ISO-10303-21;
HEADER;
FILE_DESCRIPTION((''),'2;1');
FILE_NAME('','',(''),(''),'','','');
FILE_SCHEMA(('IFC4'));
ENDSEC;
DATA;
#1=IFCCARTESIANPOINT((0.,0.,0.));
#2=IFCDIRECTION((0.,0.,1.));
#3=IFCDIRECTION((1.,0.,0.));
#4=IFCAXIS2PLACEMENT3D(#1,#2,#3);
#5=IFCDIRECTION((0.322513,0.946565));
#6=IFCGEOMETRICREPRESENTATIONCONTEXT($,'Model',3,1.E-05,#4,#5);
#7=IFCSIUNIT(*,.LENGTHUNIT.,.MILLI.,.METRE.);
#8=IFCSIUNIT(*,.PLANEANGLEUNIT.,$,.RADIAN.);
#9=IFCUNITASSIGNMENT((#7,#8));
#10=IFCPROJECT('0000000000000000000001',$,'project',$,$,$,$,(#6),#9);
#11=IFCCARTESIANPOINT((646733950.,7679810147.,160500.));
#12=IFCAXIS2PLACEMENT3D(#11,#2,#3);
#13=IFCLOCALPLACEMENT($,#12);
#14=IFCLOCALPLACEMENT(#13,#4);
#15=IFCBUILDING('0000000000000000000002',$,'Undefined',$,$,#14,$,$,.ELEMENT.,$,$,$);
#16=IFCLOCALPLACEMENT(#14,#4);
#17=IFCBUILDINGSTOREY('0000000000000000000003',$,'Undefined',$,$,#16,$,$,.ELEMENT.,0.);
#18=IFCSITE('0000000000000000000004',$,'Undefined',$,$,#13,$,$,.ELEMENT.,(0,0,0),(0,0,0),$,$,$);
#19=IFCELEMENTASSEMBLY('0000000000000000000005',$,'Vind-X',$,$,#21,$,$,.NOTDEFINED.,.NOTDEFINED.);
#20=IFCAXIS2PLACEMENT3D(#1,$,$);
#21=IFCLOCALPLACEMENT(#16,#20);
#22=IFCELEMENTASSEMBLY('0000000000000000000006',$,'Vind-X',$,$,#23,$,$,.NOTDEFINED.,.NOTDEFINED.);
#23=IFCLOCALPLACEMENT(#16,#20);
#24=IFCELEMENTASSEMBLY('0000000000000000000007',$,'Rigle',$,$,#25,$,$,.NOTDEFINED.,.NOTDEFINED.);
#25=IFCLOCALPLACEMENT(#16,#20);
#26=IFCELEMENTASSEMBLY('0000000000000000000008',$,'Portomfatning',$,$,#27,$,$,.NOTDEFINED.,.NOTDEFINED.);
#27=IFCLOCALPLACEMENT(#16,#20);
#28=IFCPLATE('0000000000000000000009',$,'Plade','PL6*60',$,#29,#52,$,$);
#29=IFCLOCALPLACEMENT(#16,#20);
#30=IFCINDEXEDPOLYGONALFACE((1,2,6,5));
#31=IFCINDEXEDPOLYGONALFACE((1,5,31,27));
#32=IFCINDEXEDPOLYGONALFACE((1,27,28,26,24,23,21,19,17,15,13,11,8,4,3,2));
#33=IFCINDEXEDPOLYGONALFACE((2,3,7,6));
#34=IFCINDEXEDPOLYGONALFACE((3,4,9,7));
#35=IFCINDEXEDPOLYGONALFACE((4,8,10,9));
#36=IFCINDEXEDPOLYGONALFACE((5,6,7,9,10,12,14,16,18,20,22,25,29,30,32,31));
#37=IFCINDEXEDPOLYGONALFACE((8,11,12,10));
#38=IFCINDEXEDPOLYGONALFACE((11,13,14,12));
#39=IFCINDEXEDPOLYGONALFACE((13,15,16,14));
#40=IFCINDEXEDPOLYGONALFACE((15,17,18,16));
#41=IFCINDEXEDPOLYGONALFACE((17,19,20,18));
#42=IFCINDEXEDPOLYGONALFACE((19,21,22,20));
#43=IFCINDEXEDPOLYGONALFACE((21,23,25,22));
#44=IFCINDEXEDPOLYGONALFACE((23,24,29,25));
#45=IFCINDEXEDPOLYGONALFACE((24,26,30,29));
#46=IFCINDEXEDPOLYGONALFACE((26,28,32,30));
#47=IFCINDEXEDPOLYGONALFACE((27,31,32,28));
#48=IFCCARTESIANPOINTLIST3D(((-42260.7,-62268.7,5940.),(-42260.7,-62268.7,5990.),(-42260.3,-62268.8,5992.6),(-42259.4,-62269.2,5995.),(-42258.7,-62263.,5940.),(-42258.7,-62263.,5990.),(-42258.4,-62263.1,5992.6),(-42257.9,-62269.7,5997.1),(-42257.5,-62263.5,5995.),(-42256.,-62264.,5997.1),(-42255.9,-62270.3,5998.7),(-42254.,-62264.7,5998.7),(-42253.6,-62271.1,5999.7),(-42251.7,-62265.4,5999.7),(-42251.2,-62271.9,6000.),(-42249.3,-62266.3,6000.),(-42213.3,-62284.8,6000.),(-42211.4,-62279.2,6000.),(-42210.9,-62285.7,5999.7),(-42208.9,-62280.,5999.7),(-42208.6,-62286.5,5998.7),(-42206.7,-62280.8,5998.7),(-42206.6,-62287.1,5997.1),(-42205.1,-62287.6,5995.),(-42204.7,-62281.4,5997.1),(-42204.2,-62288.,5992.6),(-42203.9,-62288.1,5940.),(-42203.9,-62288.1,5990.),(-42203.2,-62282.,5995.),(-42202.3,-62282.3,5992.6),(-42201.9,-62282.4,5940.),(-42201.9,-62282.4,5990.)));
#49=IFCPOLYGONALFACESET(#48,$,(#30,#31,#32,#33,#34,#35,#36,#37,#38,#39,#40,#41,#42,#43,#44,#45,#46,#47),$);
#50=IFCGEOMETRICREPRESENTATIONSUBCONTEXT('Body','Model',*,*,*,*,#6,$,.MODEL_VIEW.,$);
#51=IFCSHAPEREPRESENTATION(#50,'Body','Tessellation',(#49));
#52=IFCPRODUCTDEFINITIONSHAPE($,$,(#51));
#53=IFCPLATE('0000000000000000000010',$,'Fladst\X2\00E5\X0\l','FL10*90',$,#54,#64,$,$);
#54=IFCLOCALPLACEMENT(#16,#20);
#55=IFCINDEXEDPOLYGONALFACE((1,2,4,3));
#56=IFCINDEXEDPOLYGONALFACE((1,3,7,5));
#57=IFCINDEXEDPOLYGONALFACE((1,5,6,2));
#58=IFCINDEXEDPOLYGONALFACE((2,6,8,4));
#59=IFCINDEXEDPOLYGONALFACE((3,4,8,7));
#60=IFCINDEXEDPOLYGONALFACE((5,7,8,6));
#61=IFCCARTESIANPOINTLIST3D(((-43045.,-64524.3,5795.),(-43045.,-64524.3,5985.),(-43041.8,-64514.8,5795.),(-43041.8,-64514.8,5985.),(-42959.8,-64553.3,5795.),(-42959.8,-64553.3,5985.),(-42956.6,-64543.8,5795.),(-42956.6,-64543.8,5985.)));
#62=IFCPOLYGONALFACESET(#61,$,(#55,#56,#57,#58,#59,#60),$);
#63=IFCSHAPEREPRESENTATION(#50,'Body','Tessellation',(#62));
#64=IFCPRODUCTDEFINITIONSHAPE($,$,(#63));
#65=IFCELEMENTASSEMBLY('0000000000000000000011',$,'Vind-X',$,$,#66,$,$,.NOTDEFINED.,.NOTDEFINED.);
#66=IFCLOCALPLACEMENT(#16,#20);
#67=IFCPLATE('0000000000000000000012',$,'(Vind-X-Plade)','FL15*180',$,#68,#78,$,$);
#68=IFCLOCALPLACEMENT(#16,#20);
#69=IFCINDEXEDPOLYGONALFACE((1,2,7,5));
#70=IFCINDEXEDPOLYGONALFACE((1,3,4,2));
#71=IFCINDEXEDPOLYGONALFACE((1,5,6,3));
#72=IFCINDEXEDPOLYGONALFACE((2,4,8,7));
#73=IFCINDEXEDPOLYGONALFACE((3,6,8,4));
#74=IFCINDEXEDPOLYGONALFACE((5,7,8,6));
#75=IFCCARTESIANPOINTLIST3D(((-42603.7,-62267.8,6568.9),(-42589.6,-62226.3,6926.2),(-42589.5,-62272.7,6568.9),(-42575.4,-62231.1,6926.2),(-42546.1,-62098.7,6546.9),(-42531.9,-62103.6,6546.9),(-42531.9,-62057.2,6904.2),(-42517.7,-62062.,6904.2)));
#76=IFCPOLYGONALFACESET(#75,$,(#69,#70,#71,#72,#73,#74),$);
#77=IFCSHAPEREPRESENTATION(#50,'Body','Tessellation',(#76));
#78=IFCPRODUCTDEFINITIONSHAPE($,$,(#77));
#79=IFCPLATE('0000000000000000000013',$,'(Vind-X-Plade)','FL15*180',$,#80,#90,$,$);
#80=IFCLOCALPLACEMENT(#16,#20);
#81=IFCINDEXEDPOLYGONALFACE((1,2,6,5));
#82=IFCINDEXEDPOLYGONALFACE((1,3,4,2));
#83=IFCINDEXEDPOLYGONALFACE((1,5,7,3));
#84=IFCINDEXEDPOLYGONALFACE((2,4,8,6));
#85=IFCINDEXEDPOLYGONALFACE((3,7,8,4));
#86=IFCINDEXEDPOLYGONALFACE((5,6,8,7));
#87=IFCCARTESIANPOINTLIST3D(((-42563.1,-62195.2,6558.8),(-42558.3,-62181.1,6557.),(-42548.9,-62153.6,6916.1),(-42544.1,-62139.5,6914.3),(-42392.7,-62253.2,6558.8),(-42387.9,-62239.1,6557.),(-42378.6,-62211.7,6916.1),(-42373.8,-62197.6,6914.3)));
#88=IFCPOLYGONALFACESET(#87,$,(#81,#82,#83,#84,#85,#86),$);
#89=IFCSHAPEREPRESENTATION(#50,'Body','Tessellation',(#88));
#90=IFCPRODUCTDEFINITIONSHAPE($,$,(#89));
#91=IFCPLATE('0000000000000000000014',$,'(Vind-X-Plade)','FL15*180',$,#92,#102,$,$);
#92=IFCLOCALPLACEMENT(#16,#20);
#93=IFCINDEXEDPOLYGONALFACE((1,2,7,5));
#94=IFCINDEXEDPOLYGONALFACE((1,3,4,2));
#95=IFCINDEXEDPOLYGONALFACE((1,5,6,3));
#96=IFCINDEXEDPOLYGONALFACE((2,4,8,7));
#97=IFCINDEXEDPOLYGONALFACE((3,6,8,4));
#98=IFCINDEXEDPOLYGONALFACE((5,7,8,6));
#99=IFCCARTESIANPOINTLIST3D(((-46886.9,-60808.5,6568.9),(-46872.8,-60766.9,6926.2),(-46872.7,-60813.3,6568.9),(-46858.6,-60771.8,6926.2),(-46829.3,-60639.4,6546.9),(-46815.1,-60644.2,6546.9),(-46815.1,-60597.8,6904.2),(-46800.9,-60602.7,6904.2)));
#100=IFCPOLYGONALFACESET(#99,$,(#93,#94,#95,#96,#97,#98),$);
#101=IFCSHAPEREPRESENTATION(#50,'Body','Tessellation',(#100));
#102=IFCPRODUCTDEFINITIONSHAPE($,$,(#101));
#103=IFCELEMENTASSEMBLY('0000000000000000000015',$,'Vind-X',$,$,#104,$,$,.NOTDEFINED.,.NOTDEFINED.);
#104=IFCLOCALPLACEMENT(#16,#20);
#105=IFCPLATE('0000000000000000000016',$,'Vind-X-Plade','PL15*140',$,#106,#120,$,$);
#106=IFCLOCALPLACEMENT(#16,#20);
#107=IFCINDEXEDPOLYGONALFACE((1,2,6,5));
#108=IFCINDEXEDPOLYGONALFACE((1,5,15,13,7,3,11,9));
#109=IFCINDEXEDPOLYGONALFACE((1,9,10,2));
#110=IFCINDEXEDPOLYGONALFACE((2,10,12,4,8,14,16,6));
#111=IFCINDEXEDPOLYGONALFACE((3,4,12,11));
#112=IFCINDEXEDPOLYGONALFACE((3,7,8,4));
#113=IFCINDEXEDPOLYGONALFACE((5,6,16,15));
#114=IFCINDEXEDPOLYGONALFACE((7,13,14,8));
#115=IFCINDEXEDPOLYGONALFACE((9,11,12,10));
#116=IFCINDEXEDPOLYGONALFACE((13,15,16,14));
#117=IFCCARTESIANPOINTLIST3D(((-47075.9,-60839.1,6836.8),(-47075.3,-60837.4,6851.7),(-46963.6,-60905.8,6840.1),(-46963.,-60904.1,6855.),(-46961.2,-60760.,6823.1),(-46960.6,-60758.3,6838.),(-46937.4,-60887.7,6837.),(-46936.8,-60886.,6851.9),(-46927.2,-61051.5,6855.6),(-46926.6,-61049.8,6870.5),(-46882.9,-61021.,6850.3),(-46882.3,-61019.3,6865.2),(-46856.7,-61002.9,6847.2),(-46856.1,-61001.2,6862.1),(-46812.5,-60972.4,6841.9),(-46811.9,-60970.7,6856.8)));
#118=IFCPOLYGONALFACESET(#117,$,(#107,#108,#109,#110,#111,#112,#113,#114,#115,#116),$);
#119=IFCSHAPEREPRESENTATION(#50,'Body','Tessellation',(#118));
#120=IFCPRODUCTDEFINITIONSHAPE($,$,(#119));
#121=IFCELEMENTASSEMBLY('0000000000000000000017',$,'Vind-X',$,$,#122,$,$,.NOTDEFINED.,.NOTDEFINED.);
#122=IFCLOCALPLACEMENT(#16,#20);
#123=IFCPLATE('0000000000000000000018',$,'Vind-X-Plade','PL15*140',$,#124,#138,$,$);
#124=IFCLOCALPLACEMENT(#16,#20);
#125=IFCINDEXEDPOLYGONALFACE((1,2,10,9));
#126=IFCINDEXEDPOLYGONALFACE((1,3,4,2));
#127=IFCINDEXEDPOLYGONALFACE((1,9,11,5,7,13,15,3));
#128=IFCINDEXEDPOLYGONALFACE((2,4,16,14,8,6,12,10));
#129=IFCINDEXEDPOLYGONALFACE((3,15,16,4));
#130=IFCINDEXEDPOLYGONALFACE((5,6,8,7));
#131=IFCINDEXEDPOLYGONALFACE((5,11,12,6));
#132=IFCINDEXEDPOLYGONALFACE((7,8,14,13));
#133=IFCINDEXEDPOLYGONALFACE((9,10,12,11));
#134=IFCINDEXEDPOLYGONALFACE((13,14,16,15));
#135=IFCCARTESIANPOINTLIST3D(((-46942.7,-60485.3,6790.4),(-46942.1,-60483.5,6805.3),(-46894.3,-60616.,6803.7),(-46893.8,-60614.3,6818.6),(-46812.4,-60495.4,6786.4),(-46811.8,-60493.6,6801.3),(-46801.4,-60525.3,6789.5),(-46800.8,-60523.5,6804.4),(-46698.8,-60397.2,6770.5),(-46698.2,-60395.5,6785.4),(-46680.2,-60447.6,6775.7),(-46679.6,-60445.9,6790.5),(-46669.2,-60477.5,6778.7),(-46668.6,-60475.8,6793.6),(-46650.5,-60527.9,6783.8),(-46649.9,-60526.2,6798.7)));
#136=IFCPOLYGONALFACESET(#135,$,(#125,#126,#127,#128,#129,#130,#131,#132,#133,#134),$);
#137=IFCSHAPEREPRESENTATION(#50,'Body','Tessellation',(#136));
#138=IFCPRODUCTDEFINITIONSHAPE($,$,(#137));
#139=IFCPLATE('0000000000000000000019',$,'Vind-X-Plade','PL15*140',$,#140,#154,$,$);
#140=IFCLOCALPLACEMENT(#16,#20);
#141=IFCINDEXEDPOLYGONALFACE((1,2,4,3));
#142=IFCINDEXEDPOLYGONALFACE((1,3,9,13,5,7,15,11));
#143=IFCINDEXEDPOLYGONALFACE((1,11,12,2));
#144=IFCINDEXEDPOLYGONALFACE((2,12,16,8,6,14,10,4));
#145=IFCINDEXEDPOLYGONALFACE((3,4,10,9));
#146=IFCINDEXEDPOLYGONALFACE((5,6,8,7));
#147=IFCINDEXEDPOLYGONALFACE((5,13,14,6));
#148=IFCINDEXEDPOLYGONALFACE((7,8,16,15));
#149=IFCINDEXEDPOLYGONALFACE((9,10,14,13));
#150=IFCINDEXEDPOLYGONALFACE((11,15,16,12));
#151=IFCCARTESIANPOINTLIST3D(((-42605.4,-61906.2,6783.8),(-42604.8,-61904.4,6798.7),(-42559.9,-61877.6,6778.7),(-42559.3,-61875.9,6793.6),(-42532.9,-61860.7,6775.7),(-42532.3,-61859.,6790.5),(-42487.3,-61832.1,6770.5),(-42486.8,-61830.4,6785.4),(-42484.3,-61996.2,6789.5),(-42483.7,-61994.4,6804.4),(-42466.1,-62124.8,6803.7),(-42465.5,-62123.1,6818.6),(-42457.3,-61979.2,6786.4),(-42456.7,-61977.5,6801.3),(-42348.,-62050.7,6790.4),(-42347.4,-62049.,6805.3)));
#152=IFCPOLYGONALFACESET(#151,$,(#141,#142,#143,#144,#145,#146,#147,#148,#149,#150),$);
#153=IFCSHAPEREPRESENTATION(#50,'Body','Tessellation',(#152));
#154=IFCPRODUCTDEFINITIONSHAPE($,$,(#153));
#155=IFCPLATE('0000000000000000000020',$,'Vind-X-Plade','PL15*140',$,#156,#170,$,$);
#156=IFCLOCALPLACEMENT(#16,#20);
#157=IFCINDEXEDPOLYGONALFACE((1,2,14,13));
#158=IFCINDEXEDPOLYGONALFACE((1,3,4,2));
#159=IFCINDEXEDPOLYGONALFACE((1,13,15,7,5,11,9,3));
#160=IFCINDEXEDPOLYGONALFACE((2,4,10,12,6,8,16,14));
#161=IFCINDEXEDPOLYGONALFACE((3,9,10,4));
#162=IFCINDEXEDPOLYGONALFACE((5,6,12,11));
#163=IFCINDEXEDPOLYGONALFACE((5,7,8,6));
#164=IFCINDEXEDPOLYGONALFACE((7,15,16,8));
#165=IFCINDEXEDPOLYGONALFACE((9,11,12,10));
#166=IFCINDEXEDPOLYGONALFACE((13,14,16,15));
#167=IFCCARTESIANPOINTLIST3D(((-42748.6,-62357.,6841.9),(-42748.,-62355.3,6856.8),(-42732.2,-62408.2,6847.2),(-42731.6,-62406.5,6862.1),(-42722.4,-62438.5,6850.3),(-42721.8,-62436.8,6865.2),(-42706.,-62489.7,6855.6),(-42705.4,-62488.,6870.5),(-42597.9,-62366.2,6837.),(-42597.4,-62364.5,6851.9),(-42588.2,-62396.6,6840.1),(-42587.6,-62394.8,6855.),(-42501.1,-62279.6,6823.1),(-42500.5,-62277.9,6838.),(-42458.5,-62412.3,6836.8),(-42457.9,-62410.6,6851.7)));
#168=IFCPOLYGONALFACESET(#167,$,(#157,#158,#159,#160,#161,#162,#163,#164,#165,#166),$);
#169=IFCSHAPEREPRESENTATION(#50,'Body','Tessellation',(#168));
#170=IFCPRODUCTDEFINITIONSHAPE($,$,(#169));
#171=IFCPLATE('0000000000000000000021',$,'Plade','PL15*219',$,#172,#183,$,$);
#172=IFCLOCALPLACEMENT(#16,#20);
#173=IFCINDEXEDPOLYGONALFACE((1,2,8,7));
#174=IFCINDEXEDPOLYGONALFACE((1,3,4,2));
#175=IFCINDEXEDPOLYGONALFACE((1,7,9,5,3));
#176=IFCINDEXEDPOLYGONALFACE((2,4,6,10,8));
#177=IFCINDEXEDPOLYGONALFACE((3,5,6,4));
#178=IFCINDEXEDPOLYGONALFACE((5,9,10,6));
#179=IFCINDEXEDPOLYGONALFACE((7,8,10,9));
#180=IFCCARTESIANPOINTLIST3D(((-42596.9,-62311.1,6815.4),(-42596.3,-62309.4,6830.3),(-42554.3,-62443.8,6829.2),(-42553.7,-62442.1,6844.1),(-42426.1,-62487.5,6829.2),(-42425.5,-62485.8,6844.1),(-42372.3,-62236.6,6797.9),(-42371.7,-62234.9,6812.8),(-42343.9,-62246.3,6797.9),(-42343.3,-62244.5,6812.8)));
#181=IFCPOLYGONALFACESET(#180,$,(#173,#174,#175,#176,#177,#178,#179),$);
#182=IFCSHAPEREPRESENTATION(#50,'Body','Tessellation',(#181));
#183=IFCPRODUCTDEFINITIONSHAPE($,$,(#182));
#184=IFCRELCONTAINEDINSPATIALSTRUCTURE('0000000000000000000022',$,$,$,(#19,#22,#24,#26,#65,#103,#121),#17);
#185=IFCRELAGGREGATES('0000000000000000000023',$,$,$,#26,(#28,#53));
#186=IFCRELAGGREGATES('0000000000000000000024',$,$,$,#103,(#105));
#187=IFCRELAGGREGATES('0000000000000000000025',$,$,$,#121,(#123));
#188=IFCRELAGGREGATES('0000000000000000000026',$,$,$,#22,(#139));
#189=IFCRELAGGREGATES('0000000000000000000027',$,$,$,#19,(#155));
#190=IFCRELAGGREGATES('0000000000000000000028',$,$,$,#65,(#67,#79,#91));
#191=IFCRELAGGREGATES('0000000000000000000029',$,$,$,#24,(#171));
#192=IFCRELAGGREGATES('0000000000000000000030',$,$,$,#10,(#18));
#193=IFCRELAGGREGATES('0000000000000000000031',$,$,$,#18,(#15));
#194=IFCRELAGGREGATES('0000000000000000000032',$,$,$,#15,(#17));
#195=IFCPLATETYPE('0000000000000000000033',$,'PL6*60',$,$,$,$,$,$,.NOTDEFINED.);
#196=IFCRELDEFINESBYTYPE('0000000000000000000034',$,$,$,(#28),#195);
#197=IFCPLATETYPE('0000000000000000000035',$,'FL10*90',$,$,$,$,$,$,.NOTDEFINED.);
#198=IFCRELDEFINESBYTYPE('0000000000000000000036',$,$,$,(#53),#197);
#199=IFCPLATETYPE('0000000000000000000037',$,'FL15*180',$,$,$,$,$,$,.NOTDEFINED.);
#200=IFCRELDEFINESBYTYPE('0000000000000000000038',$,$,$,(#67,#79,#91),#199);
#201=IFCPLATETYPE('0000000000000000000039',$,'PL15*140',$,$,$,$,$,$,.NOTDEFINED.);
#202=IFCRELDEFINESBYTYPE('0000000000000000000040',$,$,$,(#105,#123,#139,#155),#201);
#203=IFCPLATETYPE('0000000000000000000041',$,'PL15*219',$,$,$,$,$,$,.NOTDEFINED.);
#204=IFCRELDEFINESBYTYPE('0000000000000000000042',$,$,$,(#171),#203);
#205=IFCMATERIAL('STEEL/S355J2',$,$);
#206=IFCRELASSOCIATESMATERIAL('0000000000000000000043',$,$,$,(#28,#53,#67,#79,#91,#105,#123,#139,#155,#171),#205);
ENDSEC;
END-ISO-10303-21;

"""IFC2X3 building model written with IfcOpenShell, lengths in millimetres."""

from ifc_helpers import new_model, si_unit, direction, frame, frame_2d, origin_with_axes, place, context, subcontext, project, spatial, polyline, circle_curve, parameter, trimmed, segment, composite_curve, outline, extrude, material, type_object, element, aggregate, save


model = new_model("IFC2X3")

# Units and contexts
model_context = context("Model", 3, precision=1e-05, world=origin_with_axes(), true_north=direction((0.322513, 0.946565)))
body_context = subcontext(model_context, "Body", "Model", "MODEL_VIEW")
ifc_project = project(units=[si_unit("LENGTHUNIT", "METRE", prefix="MILLI"), si_unit("PLANEANGLEUNIT", "RADIAN")], contexts=[model_context])

# Site, building, storey
site_placement = place(None, frame((646733950.0, 7679810147.0, 160500.0), z_axis=(0.0, 0.0, 1.0), x_axis=(1.0, 0.0, 0.0)))
site = spatial("IfcSite", under=ifc_project, at=site_placement, Name="Undefined", CompositionType="ELEMENT", RefLatitude=(0, 0, 0), RefLongitude=(0, 0, 0))
building_placement = place(site_placement, origin_with_axes())
building = spatial("IfcBuilding", under=site, at=building_placement, Name="Undefined", CompositionType="ELEMENT")
storey_placement = place(building_placement, origin_with_axes())
storey = spatial("IfcBuildingStorey", under=building, at=storey_placement, Name="Undefined", CompositionType="ELEMENT", Elevation=0.0)

# Element assemblies
assembly_1_placement = place(storey_placement, origin_with_axes())
assembly_1 = element("IfcElementAssembly", 1, at=assembly_1_placement, inside=storey, Name="Vind-X", AssemblyPlace="NOTDEFINED", PredefinedType="NOTDEFINED")
ifc_material_1 = material(Name="STEEL/S355J2")
assembly_2_placement = place(storey_placement, origin_with_axes())
assembly_2 = element("IfcElementAssembly", 2, at=assembly_2_placement, inside=storey, Name="Vind-X", AssemblyPlace="NOTDEFINED", PredefinedType="NOTDEFINED")

# Element assembly
assembly_3_placement = place(storey_placement, origin_with_axes())
assembly_3 = element("IfcElementAssembly", 3, at=assembly_3_placement, inside=storey, Name="Rigle", AssemblyPlace="NOTDEFINED", PredefinedType="NOTDEFINED")

# Element assemblies, plates
assembly_4_placement = place(storey_placement, origin_with_axes())
assembly_4 = element("IfcElementAssembly", 4, at=assembly_4_placement, inside=storey, Name="Portomfatning", AssemblyPlace="NOTDEFINED", PredefinedType="NOTDEFINED")
plate_type_1 = type_object("IfcPlateType", Name="PL6*60", PredefinedType="NOTDEFINED")
plate_1_placement = place(assembly_4_placement, frame((-42259.7, -62265.9, 5940.0), z_axis=(-0.322513, -0.946565, 0.0), x_axis=(0.946565, -0.322513, 0.0)))
plate_1 = element("IfcPlate", 5, at=plate_1_placement, type_object=plate_type_1, material=ifc_material_1, Name="Plade", Description="PL6*60", context=body_context, shape_type="SweptSolid", body=[
    extrude(outline(composite_curve([segment(polyline([(0.0, 0.0), (60.0, 0.0), (60.0, 50.0)]), True, "CONTINUOUS"), segment(trimmed(circle_curve(frame_2d((50.0, 50.0), x_axis=(1.0, 0.0)), 10.0), [parameter(0.0)], [parameter(1.570796)], True, "PARAMETER"), True, "CONTINUOUS"), segment(polyline([(50.0, 60.0), (10.0, 60.0)]), True, "CONTINUOUS"), segment(trimmed(circle_curve(frame_2d((10.0, 50.0), x_axis=(0.0, 1.0)), 10.0), [parameter(0.0)], [parameter(1.570796)], True, "PARAMETER"), True, "CONTINUOUS"), segment(polyline([(0.0, 50.0), (0.0, 0.0)]), True, "CONTINUOUS")], self_intersect=True)), frame((0.0, 0.0, -3.0), z_axis=(0.0, 0.0, 1.0), x_axis=(1.0, 0.0, 0.0)), (0.0, 0.0, 1.0), 6.0),
])
plate_type_2 = type_object("IfcPlateType", Name="FL10*90", PredefinedType="NOTDEFINED")
plate_2_placement = place(assembly_4_placement, frame((-43000.8, -64534.1, 5795.0), z_axis=(0.322513, 0.946565, 0.0), x_axis=(0.0, 0.0, 1.0)))
plate_2 = element("IfcPlate", 6, at=plate_2_placement, type_object=plate_type_2, material=ifc_material_1, Name="Fladstål", Description="FL10*90", context=body_context, shape_type="SweptSolid", body=[
    extrude(outline(polyline([(0.0, -45.0), (0.0, 45.0), (190.0, 45.0), (190.0, -45.0), (0.0, -45.0)])), frame((0.0, 0.0, -5.0), z_axis=(0.0, 0.0, 1.0), x_axis=(1.0, 0.0, 0.0)), (0.0, 0.0, 1.0), 10.0),
])
aggregate(assembly_4, [plate_1, plate_2])
assembly_5_placement = place(storey_placement, origin_with_axes())
assembly_5 = element("IfcElementAssembly", 7, at=assembly_5_placement, inside=storey, Name="Vind-X", AssemblyPlace="NOTDEFINED", PredefinedType="NOTDEFINED")
plate_type_3 = type_object("IfcPlateType", Name="FL15*180", PredefinedType="NOTDEFINED")
plate_3_placement = place(assembly_5_placement, frame((-42524.8, -62059.6, 6904.2), z_axis=(0.946565, -0.322513, 0.0), x_axis=(-0.320109, -0.93951, 0.121869)))
plate_3 = element("IfcPlate", 8, at=plate_3_placement, type_object=plate_type_3, material=ifc_material_1, Name="(Vind-X-Plade)", Description="FL15*180", context=body_context, shape_type="SweptSolid", body=[
    extrude(outline(polyline([(0.0, 0.0), (180.0, 0.0), (180.0, 360.0), (0.0, 360.0), (0.0, 0.0)])), frame((0.0, 0.0, -7.5), z_axis=(0.0, 0.0, 1.0), x_axis=(1.0, 0.0, 0.0)), (0.0, 0.0, 1.0), 15.0),
])
plate_4_placement = place(assembly_5_placement, frame((-42390.3, -62246.2, 6557.9), z_axis=(-0.320109, -0.93951, 0.121869), x_axis=(0.039304, 0.115357, 0.992546)))
plate_4 = element("IfcPlate", 9, at=plate_4_placement, type_object=plate_type_3, material=ifc_material_1, Name="(Vind-X-Plade)", Description="FL15*180", context=body_context, shape_type="SweptSolid", body=[
    extrude(outline(polyline([(0.0, 0.0), (360.0, 0.0), (360.0, 180.0), (0.0, 180.0), (0.0, 0.0)])), frame((0.0, 0.0, -7.5), z_axis=(0.0, 0.0, 1.0), x_axis=(1.0, 0.0, 0.0)), (0.0, 0.0, 1.0), 15.0),
])
plate_5_placement = place(assembly_5_placement, frame((-46865.7, -60769.4, 6926.2), z_axis=(-0.946565, 0.322513, 0.0), x_axis=(0.320109, 0.93951, -0.121869)))
plate_5 = element("IfcPlate", 10, at=plate_5_placement, type_object=plate_type_3, material=ifc_material_1, Name="(Vind-X-Plade)", Description="FL15*180", context=body_context, shape_type="SweptSolid", body=[
    extrude(outline(polyline([(0.0, 0.0), (180.0, 0.0), (180.0, 360.0), (0.0, 360.0), (0.0, 0.0)])), frame((0.0, 0.0, -7.5), z_axis=(0.0, 0.0, 1.0), x_axis=(1.0, 0.0, 0.0)), (0.0, 0.0, 1.0), 15.0),
])

# Element assemblies, plates
assembly_6_placement = place(storey_placement, origin_with_axes())
assembly_6 = element("IfcElementAssembly", 11, at=assembly_6_placement, inside=storey, Name="Vind-X", AssemblyPlace="NOTDEFINED", PredefinedType="NOTDEFINED")
plate_type_4 = type_object("IfcPlateType", Name="PL15*140", PredefinedType="NOTDEFINED")
plate_6_placement = place(assembly_6_placement, frame((-46812.2, -60971.6, 6849.3), z_axis=(0.039304, 0.115357, 0.992546), x_axis=(-0.572042, 0.817031, -0.072306)))
plate_6 = element("IfcPlate", 12, at=plate_6_placement, type_object=plate_type_4, material=ifc_material_1, Name="Vind-X-Plade", Description="PL15*140", context=body_context, shape_type="SweptSolid", body=[
    extrude(outline(polyline([(0.0, 0.0), (260.0, 0.0), (260.0, 140.0), (0.0, 140.0), (0.0, 86.0), (141.0, 86.0), (141.0, 54.0), (0.0, 54.0), (0.0, 0.0)])), frame((0.0, 0.0, -7.5), z_axis=(0.0, 0.0, 1.0), x_axis=(1.0, 0.0, 0.0)), (0.0, 0.0, 1.0), 15.0),
])
aggregate(assembly_6, [plate_6])
assembly_7_placement = place(storey_placement, origin_with_axes())
assembly_7 = element("IfcElementAssembly", 13, at=assembly_7_placement, inside=storey, Name="Vind-X", AssemblyPlace="NOTDEFINED", PredefinedType="NOTDEFINED")
plate_7_placement = place(assembly_7_placement, frame((-46698.5, -60396.3, 6778.0), z_axis=(0.039304, 0.115357, 0.992546), x_axis=(-0.937758, -0.338759, 0.076507)))
plate_7 = element("IfcPlate", 14, at=plate_7_placement, type_object=plate_type_4, material=ifc_material_1, Name="Vind-X-Plade", Description="PL15*140", context=body_context, shape_type="SweptSolid", body=[
    extrude(outline(polyline([(0.0, 0.0), (260.0, 0.0), (260.0, 140.0), (0.0, 140.0), (0.0, 86.0), (141.0, 86.0), (141.0, 54.0), (0.0, 54.0), (0.0, 0.0)])), frame((0.0, 0.0, -7.5), z_axis=(0.0, 0.0, 1.0), x_axis=(1.0, 0.0, 0.0)), (0.0, 0.0, 1.0), 15.0),
])
aggregate(assembly_7, [plate_7])

# Plates
plate_8_placement = place(assembly_2_placement, frame((-42605.1, -61905.3, 6791.3), z_axis=(0.039304, 0.115357, 0.992546), x_axis=(0.535845, -0.840843, 0.076507)))
plate_8 = element("IfcPlate", 15, at=plate_8_placement, type_object=plate_type_4, material=ifc_material_1, Name="Vind-X-Plade", Description="PL15*140", context=body_context, shape_type="SweptSolid", body=[
    extrude(outline(polyline([(0.0, 0.0), (260.0, 0.0), (260.0, 140.0), (0.0, 140.0), (0.0, 86.0), (141.0, 86.0), (141.0, 54.0), (0.0, 54.0), (0.0, 0.0)])), frame((0.0, 0.0, -7.5), z_axis=(0.0, 0.0, 1.0), x_axis=(1.0, 0.0, 0.0)), (0.0, 0.0, 1.0), 15.0),
])
plate_9_placement = place(assembly_1_placement, frame((-42705.7, -62488.8, 6863.1), z_axis=(0.039304, 0.115357, 0.992546), x_axis=(0.951886, 0.297802, -0.072306)))
plate_9 = element("IfcPlate", 16, at=plate_9_placement, type_object=plate_type_4, material=ifc_material_1, Name="Vind-X-Plade", Description="PL15*140", context=body_context, shape_type="SweptSolid", body=[
    extrude(outline(polyline([(0.0, 0.0), (260.0, 0.0), (260.0, 140.0), (0.0, 140.0), (0.0, 86.0), (141.0, 86.0), (141.0, 54.0), (0.0, 54.0), (0.0, 0.0)])), frame((0.0, 0.0, -7.5), z_axis=(0.0, 0.0, 1.0), x_axis=(1.0, 0.0, 0.0)), (0.0, 0.0, 1.0), 15.0),
])
plate_type_5 = type_object("IfcPlateType", Name="PL15*219", PredefinedType="NOTDEFINED")
plate_10_placement = place(assembly_3_placement, frame((-42425.8, -62486.6, 6836.6), z_axis=(0.039304, 0.115357, 0.992546), x_axis=(0.320109, 0.93951, -0.121869)))
plate_10 = element("IfcPlate", 17, at=plate_10_placement, type_object=plate_type_5, material=ifc_material_1, Name="Plade", Description="PL15*219", context=body_context, shape_type="SweptSolid", body=[
    extrude(outline(polyline([(0.0, 0.0), (256.8, 0.0), (256.8, 30.0), (112.7, 218.6), (0.0, 135.5), (0.0, 0.0)])), frame((0.0, 0.0, -7.5), z_axis=(0.0, 0.0, 1.0), x_axis=(1.0, 0.0, 0.0)), (0.0, 0.0, 1.0), 15.0),
])

aggregate(assembly_2, [plate_8])
aggregate(assembly_1, [plate_9])
aggregate(assembly_5, [plate_3, plate_4, plate_5])
aggregate(assembly_3, [plate_10])

save(model, "model.ifc")
